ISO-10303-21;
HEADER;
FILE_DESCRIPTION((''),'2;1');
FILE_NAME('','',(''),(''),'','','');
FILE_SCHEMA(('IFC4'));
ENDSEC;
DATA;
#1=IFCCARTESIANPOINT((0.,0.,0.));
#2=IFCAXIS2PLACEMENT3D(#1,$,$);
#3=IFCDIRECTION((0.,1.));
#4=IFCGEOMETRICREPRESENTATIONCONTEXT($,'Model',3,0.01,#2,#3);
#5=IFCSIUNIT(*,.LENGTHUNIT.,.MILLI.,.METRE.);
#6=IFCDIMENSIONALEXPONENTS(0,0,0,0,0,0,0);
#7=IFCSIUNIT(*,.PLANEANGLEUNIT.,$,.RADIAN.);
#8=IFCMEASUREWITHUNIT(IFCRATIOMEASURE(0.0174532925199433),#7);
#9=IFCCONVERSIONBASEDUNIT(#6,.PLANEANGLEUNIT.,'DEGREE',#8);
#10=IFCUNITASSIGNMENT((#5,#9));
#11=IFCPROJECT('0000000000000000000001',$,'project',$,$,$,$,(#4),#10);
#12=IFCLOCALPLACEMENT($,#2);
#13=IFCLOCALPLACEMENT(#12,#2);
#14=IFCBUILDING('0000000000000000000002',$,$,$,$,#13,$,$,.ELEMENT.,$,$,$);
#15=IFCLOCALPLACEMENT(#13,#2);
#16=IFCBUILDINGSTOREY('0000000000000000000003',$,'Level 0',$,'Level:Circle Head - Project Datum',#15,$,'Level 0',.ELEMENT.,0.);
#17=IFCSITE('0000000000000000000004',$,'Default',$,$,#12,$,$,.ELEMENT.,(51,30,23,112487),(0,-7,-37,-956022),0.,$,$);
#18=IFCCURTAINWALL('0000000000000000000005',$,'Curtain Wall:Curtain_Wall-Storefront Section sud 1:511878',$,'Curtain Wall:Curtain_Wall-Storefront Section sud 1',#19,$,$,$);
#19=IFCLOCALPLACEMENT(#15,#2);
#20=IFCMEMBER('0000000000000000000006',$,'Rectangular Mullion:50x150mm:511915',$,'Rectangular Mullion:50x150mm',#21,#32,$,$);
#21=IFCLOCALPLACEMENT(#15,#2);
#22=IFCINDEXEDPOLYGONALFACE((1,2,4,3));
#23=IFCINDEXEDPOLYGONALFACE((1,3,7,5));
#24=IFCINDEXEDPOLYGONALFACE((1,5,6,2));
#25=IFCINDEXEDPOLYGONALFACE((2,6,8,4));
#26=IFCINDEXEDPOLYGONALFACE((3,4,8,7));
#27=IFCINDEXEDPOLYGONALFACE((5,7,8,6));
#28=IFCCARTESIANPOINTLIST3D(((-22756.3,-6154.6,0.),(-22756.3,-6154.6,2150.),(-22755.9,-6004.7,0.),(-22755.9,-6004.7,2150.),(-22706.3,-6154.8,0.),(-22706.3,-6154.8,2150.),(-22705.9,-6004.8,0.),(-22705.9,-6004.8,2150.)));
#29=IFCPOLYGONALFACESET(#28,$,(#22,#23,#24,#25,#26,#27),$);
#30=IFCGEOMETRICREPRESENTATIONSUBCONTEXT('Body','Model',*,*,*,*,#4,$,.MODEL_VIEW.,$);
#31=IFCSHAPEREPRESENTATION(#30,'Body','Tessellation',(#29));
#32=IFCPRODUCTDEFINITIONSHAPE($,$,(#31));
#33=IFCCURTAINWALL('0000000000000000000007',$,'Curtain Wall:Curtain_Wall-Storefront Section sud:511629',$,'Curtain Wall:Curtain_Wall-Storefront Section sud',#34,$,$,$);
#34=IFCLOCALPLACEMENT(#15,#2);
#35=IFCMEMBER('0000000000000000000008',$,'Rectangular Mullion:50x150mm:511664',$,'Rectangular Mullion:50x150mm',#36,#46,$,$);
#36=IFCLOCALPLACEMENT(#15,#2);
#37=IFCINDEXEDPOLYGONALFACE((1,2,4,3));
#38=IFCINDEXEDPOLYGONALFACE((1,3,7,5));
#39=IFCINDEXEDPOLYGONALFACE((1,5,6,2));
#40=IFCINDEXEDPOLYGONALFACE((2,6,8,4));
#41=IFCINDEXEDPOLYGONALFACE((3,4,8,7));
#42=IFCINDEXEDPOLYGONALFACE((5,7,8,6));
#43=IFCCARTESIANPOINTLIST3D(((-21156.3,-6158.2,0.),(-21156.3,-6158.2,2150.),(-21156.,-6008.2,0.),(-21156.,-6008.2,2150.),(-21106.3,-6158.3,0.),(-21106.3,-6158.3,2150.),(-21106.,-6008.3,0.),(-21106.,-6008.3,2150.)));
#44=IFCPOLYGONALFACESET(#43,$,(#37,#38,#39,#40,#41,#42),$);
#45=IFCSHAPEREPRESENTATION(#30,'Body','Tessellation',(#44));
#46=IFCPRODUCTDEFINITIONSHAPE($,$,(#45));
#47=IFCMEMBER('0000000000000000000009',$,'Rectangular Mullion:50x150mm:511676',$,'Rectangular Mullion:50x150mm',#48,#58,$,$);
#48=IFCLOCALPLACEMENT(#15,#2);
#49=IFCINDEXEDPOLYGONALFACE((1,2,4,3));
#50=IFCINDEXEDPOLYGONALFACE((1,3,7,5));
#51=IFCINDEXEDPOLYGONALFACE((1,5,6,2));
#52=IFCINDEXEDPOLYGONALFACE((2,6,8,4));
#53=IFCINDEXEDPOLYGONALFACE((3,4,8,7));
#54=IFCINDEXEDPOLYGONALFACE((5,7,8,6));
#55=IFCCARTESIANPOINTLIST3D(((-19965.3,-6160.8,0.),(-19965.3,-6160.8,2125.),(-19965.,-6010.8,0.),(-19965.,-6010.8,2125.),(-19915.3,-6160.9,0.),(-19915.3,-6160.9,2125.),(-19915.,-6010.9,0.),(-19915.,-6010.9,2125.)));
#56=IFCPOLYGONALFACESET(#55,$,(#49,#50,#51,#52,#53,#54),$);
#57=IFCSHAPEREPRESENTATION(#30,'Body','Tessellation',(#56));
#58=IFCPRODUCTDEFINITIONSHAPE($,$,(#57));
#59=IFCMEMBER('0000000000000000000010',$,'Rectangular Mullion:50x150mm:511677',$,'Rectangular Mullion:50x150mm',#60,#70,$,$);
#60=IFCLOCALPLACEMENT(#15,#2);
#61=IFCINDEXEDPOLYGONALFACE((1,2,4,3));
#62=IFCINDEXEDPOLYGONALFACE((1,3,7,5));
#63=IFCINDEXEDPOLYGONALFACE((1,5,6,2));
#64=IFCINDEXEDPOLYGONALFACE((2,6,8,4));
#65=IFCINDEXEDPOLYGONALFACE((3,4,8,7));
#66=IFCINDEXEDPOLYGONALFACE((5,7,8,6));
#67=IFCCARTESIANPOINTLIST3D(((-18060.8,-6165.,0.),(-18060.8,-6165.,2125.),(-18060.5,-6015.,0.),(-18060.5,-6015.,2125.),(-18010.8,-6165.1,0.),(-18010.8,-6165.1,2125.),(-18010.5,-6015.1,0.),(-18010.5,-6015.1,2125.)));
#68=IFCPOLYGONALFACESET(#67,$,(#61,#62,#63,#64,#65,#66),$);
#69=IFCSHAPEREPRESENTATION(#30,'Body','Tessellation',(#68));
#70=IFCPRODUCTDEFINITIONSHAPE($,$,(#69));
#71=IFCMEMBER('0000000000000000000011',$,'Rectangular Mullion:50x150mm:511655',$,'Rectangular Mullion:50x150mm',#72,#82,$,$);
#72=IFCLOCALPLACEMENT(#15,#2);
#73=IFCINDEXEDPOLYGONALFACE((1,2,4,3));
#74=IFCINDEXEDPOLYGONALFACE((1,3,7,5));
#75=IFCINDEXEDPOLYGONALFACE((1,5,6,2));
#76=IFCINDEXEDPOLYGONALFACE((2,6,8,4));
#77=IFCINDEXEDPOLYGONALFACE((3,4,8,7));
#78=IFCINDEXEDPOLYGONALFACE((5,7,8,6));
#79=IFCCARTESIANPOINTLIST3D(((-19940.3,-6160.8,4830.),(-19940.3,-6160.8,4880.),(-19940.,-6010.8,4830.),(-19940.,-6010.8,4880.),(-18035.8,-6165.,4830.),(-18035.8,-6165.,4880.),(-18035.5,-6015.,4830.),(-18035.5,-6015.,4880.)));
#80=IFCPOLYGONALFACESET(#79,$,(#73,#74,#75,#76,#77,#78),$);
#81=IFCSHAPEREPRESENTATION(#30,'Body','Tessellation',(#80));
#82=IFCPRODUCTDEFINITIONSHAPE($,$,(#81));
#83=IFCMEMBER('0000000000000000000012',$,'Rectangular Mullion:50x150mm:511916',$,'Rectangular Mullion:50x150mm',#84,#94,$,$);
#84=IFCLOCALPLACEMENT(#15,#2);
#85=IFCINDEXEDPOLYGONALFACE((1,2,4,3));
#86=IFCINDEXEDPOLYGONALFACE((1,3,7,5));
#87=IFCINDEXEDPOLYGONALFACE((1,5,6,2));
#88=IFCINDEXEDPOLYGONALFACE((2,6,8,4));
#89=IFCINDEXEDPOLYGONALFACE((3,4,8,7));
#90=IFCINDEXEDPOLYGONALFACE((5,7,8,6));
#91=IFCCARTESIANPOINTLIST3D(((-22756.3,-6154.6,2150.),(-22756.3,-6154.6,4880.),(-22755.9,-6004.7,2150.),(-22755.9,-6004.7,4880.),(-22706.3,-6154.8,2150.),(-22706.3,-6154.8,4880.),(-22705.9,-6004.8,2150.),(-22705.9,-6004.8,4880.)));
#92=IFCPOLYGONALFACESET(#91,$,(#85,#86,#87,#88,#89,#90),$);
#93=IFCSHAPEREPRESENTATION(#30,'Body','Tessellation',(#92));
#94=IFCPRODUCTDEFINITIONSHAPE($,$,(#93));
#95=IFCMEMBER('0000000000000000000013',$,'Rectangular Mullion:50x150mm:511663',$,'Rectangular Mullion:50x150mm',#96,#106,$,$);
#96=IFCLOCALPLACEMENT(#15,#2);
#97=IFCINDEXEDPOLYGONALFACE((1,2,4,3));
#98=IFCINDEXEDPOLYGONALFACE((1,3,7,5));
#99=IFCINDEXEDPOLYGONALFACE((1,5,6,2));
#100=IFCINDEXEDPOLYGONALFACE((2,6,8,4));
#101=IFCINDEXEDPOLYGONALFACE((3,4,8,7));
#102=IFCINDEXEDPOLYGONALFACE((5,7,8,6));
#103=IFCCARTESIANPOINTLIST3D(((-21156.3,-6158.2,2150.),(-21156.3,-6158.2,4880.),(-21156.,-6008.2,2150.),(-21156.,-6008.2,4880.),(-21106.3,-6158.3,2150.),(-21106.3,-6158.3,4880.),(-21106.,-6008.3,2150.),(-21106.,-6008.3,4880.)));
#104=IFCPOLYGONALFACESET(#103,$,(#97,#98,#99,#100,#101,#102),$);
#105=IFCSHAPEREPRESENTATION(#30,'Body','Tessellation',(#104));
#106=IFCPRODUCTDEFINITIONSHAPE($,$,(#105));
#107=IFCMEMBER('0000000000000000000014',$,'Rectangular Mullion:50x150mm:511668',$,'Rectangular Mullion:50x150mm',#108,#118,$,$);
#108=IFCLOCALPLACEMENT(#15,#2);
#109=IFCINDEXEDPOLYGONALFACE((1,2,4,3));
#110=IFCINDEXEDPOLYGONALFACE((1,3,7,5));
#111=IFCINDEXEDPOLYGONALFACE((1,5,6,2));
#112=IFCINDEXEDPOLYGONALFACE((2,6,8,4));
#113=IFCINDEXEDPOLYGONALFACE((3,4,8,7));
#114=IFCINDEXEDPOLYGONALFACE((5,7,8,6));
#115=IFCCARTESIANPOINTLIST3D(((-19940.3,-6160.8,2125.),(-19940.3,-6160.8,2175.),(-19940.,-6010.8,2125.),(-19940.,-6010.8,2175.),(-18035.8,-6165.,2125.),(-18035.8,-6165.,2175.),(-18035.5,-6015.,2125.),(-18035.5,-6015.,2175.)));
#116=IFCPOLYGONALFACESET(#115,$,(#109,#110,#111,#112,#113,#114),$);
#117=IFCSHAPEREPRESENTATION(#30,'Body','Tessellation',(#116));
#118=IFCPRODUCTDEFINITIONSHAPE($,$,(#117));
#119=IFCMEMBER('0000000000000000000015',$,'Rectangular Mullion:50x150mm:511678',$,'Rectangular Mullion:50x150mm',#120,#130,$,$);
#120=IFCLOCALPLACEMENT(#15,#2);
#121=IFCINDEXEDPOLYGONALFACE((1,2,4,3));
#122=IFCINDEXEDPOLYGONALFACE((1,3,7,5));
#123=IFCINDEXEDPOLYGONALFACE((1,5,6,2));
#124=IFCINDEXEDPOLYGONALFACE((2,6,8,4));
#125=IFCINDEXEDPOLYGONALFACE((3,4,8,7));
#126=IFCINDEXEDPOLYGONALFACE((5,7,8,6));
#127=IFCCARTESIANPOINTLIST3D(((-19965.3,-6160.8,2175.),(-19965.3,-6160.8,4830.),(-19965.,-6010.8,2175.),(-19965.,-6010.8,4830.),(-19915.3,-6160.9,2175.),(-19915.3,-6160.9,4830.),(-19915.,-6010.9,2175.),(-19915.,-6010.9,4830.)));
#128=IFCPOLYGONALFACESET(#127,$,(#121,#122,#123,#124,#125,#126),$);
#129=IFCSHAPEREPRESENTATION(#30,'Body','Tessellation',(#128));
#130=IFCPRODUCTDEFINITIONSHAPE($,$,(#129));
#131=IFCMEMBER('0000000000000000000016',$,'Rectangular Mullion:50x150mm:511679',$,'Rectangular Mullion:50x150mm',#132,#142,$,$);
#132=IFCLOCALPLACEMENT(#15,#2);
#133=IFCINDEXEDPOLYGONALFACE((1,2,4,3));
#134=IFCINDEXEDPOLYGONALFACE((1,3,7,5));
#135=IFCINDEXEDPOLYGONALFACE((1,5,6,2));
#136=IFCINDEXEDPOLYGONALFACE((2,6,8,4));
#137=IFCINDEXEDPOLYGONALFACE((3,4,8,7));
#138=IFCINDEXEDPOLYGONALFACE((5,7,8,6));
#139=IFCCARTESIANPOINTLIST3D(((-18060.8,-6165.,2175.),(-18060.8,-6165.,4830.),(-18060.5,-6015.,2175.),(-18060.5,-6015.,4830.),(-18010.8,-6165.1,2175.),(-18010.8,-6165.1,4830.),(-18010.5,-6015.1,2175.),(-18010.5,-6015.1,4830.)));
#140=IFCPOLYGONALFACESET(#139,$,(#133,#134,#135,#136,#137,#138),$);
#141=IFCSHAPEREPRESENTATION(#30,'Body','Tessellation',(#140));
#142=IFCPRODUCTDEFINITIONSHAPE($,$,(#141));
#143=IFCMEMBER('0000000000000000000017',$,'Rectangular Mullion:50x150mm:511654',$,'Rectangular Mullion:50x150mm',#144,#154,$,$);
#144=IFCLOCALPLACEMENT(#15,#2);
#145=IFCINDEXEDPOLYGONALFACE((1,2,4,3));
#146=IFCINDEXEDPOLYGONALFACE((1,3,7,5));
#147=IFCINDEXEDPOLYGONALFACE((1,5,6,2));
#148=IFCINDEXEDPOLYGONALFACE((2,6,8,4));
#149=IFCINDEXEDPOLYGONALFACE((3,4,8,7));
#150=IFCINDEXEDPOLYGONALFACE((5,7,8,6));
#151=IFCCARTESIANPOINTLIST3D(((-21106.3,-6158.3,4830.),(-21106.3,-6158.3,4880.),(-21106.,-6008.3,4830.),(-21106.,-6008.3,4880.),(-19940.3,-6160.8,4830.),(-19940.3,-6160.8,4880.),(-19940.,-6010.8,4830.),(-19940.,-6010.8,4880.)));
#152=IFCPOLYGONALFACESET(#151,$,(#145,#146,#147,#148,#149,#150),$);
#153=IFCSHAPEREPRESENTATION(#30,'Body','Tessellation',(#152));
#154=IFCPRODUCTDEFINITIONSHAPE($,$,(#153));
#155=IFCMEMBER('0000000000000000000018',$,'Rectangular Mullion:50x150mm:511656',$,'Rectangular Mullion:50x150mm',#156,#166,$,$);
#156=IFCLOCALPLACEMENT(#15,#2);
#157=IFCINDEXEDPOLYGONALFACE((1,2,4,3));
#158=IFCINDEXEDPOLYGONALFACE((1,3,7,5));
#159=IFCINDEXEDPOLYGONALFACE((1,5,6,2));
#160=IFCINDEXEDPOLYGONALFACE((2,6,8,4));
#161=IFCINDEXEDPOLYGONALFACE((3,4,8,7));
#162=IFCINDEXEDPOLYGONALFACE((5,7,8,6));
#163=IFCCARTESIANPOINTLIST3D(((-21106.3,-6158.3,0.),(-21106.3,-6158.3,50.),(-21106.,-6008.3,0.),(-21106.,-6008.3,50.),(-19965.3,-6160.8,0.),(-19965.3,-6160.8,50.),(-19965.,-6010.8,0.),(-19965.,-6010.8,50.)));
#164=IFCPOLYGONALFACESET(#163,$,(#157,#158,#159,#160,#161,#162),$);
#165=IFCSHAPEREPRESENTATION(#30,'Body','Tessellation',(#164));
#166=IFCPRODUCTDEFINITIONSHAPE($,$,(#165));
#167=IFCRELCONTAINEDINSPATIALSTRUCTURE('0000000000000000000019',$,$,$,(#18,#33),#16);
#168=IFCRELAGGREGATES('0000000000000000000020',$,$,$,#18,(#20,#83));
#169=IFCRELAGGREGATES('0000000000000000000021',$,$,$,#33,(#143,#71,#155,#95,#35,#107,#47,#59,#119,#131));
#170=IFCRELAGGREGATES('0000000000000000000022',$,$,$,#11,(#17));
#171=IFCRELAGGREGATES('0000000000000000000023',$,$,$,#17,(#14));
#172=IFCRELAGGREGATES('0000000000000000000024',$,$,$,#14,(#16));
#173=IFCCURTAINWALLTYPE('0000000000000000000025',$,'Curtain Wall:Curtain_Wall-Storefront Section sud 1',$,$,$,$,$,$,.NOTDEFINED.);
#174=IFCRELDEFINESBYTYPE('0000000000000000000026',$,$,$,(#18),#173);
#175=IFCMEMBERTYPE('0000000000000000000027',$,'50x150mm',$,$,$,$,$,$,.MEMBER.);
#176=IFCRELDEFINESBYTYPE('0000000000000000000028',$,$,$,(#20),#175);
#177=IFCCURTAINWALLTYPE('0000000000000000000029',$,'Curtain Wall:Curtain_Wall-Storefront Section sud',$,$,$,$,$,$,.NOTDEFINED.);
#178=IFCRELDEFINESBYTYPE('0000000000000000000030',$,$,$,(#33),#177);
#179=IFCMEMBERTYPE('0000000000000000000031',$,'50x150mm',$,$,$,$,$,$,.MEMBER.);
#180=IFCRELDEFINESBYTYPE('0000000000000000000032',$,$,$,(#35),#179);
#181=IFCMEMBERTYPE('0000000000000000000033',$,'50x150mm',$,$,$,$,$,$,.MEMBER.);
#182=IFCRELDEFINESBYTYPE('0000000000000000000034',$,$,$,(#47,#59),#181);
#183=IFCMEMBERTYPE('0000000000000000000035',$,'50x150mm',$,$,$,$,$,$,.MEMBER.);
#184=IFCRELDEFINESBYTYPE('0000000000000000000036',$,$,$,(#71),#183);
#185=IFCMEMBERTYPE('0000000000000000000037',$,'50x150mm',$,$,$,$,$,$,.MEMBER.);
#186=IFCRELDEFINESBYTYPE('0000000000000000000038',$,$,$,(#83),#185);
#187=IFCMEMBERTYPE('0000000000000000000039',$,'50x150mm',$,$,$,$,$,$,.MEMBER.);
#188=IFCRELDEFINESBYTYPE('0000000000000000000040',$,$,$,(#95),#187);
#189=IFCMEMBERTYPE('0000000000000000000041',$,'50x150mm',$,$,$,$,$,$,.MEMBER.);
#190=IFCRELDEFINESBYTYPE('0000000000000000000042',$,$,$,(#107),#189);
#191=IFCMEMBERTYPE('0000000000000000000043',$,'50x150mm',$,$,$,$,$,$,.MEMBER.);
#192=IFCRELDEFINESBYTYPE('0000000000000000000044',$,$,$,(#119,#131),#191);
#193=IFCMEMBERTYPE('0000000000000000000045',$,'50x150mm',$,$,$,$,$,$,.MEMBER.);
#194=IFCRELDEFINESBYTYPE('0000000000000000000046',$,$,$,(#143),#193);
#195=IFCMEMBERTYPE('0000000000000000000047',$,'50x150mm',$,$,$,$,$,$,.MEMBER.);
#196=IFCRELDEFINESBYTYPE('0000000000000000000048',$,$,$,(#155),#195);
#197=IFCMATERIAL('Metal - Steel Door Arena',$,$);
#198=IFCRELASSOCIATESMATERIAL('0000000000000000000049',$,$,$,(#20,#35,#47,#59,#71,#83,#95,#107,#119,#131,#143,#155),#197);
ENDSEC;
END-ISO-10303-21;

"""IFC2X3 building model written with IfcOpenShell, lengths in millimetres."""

from ifc_helpers import new_model, entity, si_unit, converted_unit, direction, frame, origin, origin_2d_with_axis, place, context, subcontext, project, spatial, rectangle, extrude, source, transform, mapped, material, type_object, type_shapes, element, aggregate, save


model = new_model("IFC2X3")

# Units and contexts
model_context = context("Model", 3, precision=0.01, world=origin(), true_north=direction((0.0, 1.0)))
body_context = subcontext(model_context, "Body", "Model", "MODEL_VIEW")
ifc_project = project(units=[si_unit("LENGTHUNIT", "METRE", prefix="MILLI"), converted_unit("PLANEANGLEUNIT", "DEGREE", entity("IfcRatioMeasure", 0.0174532925199433), si_unit("PLANEANGLEUNIT", "RADIAN"), dimensions=[0, 0, 0, 0, 0, 0, 0])], contexts=[model_context])

# Site, building, storey
site_placement = place(None, origin())
site = spatial("IfcSite", under=ifc_project, at=site_placement, Name="Default", CompositionType="ELEMENT", RefLatitude=(51, 30, 23, 112487), RefLongitude=(0, -7, -37, -956022), RefElevation=0.0)
building_placement = place(site_placement, origin())
building = spatial("IfcBuilding", under=site, at=building_placement, CompositionType="ELEMENT")
storey_placement = place(building_placement, origin())
storey = spatial("IfcBuildingStorey", under=building, at=storey_placement, Name="Level 0", ObjectType="Level:Circle Head - Project Datum", LongName="Level 0", CompositionType="ELEMENT", Elevation=0.0)

# Curtain wall, member
curtain_wall_type_1 = type_object("IfcCurtainWallType", Name="Curtain Wall:Curtain_Wall-Storefront Section sud 1", PredefinedType="NOTDEFINED")
curtain_wall_1_placement = place(storey_placement, origin())
curtain_wall_1 = element("IfcCurtainWall", 1, at=curtain_wall_1_placement, inside=storey, type_object=curtain_wall_type_1, Name="Curtain Wall:Curtain_Wall-Storefront Section sud 1:511878", ObjectType="Curtain Wall:Curtain_Wall-Storefront Section sud 1")
ifc_material_1 = material(Name="Metal - Steel Door Arena")
member_type_1 = type_object("IfcMemberType", Name="50x150mm", PredefinedType="MEMBER")
shared_shape_1 = source(origin(), body_context, "Body", "SweptSolid", [
    extrude(rectangle(XDim=150.0, YDim=50.0, at=origin_2d_with_axis()), frame((-25.0, 0.0, -2150.0), z_axis=(0.0, 0.0, 1.0), x_axis=(0.0, -1.0, 0.0)), (0.0, 0.0, 1.0), 2150.0),
])
type_shapes(member_type_1, [shared_shape_1])
member_1_placement = place(storey_placement, frame((-22706.1, -6079.8, 0.0), z_axis=(0.0, 0.0, -1.0), x_axis=(0.999998, -0.002199, 0.0)))
member_1 = element("IfcMember", 2, at=member_1_placement, type_object=member_type_1, material=ifc_material_1, Name="Rectangular Mullion:50x150mm:511915", ObjectType="Rectangular Mullion:50x150mm", context=body_context, shape_type="MappedRepresentation", body=[
    mapped(shared_shape_1, transform((0.0, 0.0, 0.0), scale=1.0)),
])

# Curtain wall, members
curtain_wall_type_2 = type_object("IfcCurtainWallType", Name="Curtain Wall:Curtain_Wall-Storefront Section sud", PredefinedType="NOTDEFINED")
curtain_wall_2_placement = place(storey_placement, origin())
curtain_wall_2 = element("IfcCurtainWall", 3, at=curtain_wall_2_placement, inside=storey, type_object=curtain_wall_type_2, Name="Curtain Wall:Curtain_Wall-Storefront Section sud:511629", ObjectType="Curtain Wall:Curtain_Wall-Storefront Section sud")
member_type_2 = type_object("IfcMemberType", Name="50x150mm", PredefinedType="MEMBER")
shared_shape_2 = source(origin(), body_context, "Body", "SweptSolid", [
    extrude(rectangle(XDim=150.0, YDim=50.0, at=origin_2d_with_axis()), frame((-25.0, 0.0, -2150.0), z_axis=(0.0, 0.0, 1.0), x_axis=(0.0, -1.0, 0.0)), (0.0, 0.0, 1.0), 2150.0),
])
type_shapes(member_type_2, [shared_shape_2])
member_2_placement = place(storey_placement, frame((-21156.1, -6083.2, 2150.0), z_axis=(0.0, 0.0, 1.0), x_axis=(-0.999998, 0.002199, 0.0)))
member_2 = element("IfcMember", 4, at=member_2_placement, type_object=member_type_2, material=ifc_material_1, Name="Rectangular Mullion:50x150mm:511664", ObjectType="Rectangular Mullion:50x150mm", context=body_context, shape_type="MappedRepresentation", body=[
    mapped(shared_shape_2, transform((0.0, 0.0, 0.0), scale=1.0)),
])
member_type_3 = type_object("IfcMemberType", Name="50x150mm", PredefinedType="MEMBER")
shared_shape_3 = source(origin(), body_context, "Body", "SweptSolid", [
    extrude(rectangle(XDim=150.0, YDim=50.0, at=origin_2d_with_axis()), frame((0.0, 0.0, -2125.0), z_axis=(0.0, 0.0, 1.0), x_axis=(0.0, -1.0, 0.0)), (0.0, 0.0, 1.0), 2125.0),
])
type_shapes(member_type_3, [shared_shape_3])
member_3_placement = place(storey_placement, frame((-19940.1, -6085.8, 0.0), z_axis=(0.0, 0.0, -1.0), x_axis=(0.999998, -0.002199, 0.0)))
member_3 = element("IfcMember", 5, at=member_3_placement, type_object=member_type_3, material=ifc_material_1, Name="Rectangular Mullion:50x150mm:511676", ObjectType="Rectangular Mullion:50x150mm", context=body_context, shape_type="MappedRepresentation", body=[
    mapped(shared_shape_3, transform((0.0, 0.0, 0.0), scale=1.0)),
])
member_4_placement = place(storey_placement, frame((-18035.6, -6090.0, 0.0), z_axis=(0.0, 0.0, -1.0), x_axis=(0.999998, -0.002199, 0.0)))
member_4 = element("IfcMember", 6, at=member_4_placement, type_object=member_type_3, material=ifc_material_1, Name="Rectangular Mullion:50x150mm:511677", ObjectType="Rectangular Mullion:50x150mm", context=body_context, shape_type="MappedRepresentation", body=[
    mapped(shared_shape_3, transform((0.0, 0.0, 0.0), scale=1.0)),
])
member_type_4 = type_object("IfcMemberType", Name="50x150mm", PredefinedType="MEMBER")
shared_shape_4 = source(origin(), body_context, "Body", "SweptSolid", [
    extrude(rectangle(XDim=150.0, YDim=50.0, at=origin_2d_with_axis()), frame((-25.0, 0.0, -1904.5), z_axis=(0.0, 0.0, 1.0), x_axis=(0.0, -1.0, 0.0)), (0.0, 0.0, 1.0), 1904.5),
])
type_shapes(member_type_4, [shared_shape_4])
member_5_placement = place(storey_placement, frame((-18035.6, -6090.0, 4880.0), z_axis=(0.999998, -0.002199, 0.0), x_axis=(0.0, 0.0, 1.0)))
member_5 = element("IfcMember", 7, at=member_5_placement, type_object=member_type_4, material=ifc_material_1, Name="Rectangular Mullion:50x150mm:511655", ObjectType="Rectangular Mullion:50x150mm", context=body_context, shape_type="MappedRepresentation", body=[
    mapped(shared_shape_4, transform((0.0, 0.0, 0.0), scale=1.0)),
])

# Members
member_type_5 = type_object("IfcMemberType", Name="50x150mm", PredefinedType="MEMBER")
shared_shape_5 = source(origin(), body_context, "Body", "SweptSolid", [
    extrude(rectangle(XDim=150.0, YDim=50.0, at=origin_2d_with_axis()), frame((-25.0, 0.0, -2730.0), z_axis=(0.0, 0.0, 1.0), x_axis=(0.0, -1.0, 0.0)), (0.0, 0.0, 1.0), 2730.0),
])
type_shapes(member_type_5, [shared_shape_5])
member_6_placement = place(storey_placement, frame((-22706.1, -6079.8, 2150.0), z_axis=(0.0, 0.0, -1.0), x_axis=(0.999998, -0.002199, 0.0)))
member_6 = element("IfcMember", 8, at=member_6_placement, type_object=member_type_5, material=ifc_material_1, Name="Rectangular Mullion:50x150mm:511916", ObjectType="Rectangular Mullion:50x150mm", context=body_context, shape_type="MappedRepresentation", body=[
    mapped(shared_shape_5, transform((0.0, 0.0, 0.0), scale=1.0)),
])
member_type_6 = type_object("IfcMemberType", Name="50x150mm", PredefinedType="MEMBER")
shared_shape_6 = source(origin(), body_context, "Body", "SweptSolid", [
    extrude(rectangle(XDim=150.0, YDim=50.0, at=origin_2d_with_axis()), frame((-25.0, 0.0, -2730.0), z_axis=(0.0, 0.0, 1.0), x_axis=(0.0, -1.0, 0.0)), (0.0, 0.0, 1.0), 2730.0),
])
type_shapes(member_type_6, [shared_shape_6])
member_7_placement = place(storey_placement, frame((-21156.1, -6083.2, 4880.0), z_axis=(0.0, 0.0, 1.0), x_axis=(-0.999998, 0.002199, 0.0)))
member_7 = element("IfcMember", 9, at=member_7_placement, type_object=member_type_6, material=ifc_material_1, Name="Rectangular Mullion:50x150mm:511663", ObjectType="Rectangular Mullion:50x150mm", context=body_context, shape_type="MappedRepresentation", body=[
    mapped(shared_shape_6, transform((0.0, 0.0, 0.0), scale=1.0)),
])
member_type_7 = type_object("IfcMemberType", Name="50x150mm", PredefinedType="MEMBER")
shared_shape_7 = source(origin(), body_context, "Body", "SweptSolid", [
    extrude(rectangle(XDim=150.0, YDim=50.0, at=origin_2d_with_axis()), frame((0.0, 0.0, -1904.5), z_axis=(0.0, 0.0, 1.0), x_axis=(0.0, -1.0, 0.0)), (0.0, 0.0, 1.0), 1904.5),
])
type_shapes(member_type_7, [shared_shape_7])
member_8_placement = place(storey_placement, frame((-18035.6, -6090.0, 2150.0), z_axis=(0.999998, -0.002199, 0.0), x_axis=(0.0, 0.0, 1.0)))
member_8 = element("IfcMember", 10, at=member_8_placement, type_object=member_type_7, material=ifc_material_1, Name="Rectangular Mullion:50x150mm:511668", ObjectType="Rectangular Mullion:50x150mm", context=body_context, shape_type="MappedRepresentation", body=[
    mapped(shared_shape_7, transform((0.0, 0.0, 0.0), scale=1.0)),
])
member_type_8 = type_object("IfcMemberType", Name="50x150mm", PredefinedType="MEMBER")
shared_shape_8 = source(origin(), body_context, "Body", "SweptSolid", [
    extrude(rectangle(XDim=150.0, YDim=50.0, at=origin_2d_with_axis()), frame((0.0, 0.0, -2655.0), z_axis=(0.0, 0.0, 1.0), x_axis=(0.0, -1.0, 0.0)), (0.0, 0.0, 1.0), 2655.0),
])
type_shapes(member_type_8, [shared_shape_8])
member_9_placement = place(storey_placement, frame((-19940.1, -6085.8, 2175.0), z_axis=(0.0, 0.0, -1.0), x_axis=(0.999998, -0.002199, 0.0)))
member_9 = element("IfcMember", 11, at=member_9_placement, type_object=member_type_8, material=ifc_material_1, Name="Rectangular Mullion:50x150mm:511678", ObjectType="Rectangular Mullion:50x150mm", context=body_context, shape_type="MappedRepresentation", body=[
    mapped(shared_shape_8, transform((0.0, 0.0, 0.0), scale=1.0)),
])
member_10_placement = place(storey_placement, frame((-18035.6, -6090.0, 2175.0), z_axis=(0.0, 0.0, -1.0), x_axis=(0.999998, -0.002199, 0.0)))
member_10 = element("IfcMember", 12, at=member_10_placement, type_object=member_type_8, material=ifc_material_1, Name="Rectangular Mullion:50x150mm:511679", ObjectType="Rectangular Mullion:50x150mm", context=body_context, shape_type="MappedRepresentation", body=[
    mapped(shared_shape_8, transform((0.0, 0.0, 0.0), scale=1.0)),
])
member_type_9 = type_object("IfcMemberType", Name="50x150mm", PredefinedType="MEMBER")
shared_shape_9 = source(origin(), body_context, "Body", "SweptSolid", [
    extrude(rectangle(XDim=150.0, YDim=50.0, at=origin_2d_with_axis()), frame((-25.0, 0.0, -1166.0), z_axis=(0.0, 0.0, 1.0), x_axis=(0.0, -1.0, 0.0)), (0.0, 0.0, 1.0), 1166.0),
])
type_shapes(member_type_9, [shared_shape_9])
member_11_placement = place(storey_placement, frame((-19940.1, -6085.8, 4880.0), z_axis=(0.999998, -0.002199, 0.0), x_axis=(0.0, 0.0, 1.0)))
member_11 = element("IfcMember", 13, at=member_11_placement, type_object=member_type_9, material=ifc_material_1, Name="Rectangular Mullion:50x150mm:511654", ObjectType="Rectangular Mullion:50x150mm", context=body_context, shape_type="MappedRepresentation", body=[
    mapped(shared_shape_9, transform((0.0, 0.0, 0.0), scale=1.0)),
])
member_type_10 = type_object("IfcMemberType", Name="50x150mm", PredefinedType="MEMBER")
shared_shape_10 = source(origin(), body_context, "Body", "SweptSolid", [
    extrude(rectangle(XDim=150.0, YDim=50.0, at=origin_2d_with_axis()), frame((-25.0, 0.0, -1141.0), z_axis=(0.0, 0.0, 1.0), x_axis=(0.0, -1.0, 0.0)), (0.0, 0.0, 1.0), 1141.0),
])
type_shapes(member_type_10, [shared_shape_10])
member_12_placement = place(storey_placement, frame((-21106.1, -6083.3, 0.0), z_axis=(-0.999998, 0.002199, 0.0), x_axis=(0.0, 0.0, -1.0)))
member_12 = element("IfcMember", 14, at=member_12_placement, type_object=member_type_10, material=ifc_material_1, Name="Rectangular Mullion:50x150mm:511656", ObjectType="Rectangular Mullion:50x150mm", context=body_context, shape_type="MappedRepresentation", body=[
    mapped(shared_shape_10, transform((0.0, 0.0, 0.0), scale=1.0)),
])
aggregate(curtain_wall_1, [member_1, member_6])

aggregate(curtain_wall_2, [member_11, member_5, member_12, member_7, member_2, member_8, member_3, member_4, member_9, member_10])

save(model, "model.ifc")
